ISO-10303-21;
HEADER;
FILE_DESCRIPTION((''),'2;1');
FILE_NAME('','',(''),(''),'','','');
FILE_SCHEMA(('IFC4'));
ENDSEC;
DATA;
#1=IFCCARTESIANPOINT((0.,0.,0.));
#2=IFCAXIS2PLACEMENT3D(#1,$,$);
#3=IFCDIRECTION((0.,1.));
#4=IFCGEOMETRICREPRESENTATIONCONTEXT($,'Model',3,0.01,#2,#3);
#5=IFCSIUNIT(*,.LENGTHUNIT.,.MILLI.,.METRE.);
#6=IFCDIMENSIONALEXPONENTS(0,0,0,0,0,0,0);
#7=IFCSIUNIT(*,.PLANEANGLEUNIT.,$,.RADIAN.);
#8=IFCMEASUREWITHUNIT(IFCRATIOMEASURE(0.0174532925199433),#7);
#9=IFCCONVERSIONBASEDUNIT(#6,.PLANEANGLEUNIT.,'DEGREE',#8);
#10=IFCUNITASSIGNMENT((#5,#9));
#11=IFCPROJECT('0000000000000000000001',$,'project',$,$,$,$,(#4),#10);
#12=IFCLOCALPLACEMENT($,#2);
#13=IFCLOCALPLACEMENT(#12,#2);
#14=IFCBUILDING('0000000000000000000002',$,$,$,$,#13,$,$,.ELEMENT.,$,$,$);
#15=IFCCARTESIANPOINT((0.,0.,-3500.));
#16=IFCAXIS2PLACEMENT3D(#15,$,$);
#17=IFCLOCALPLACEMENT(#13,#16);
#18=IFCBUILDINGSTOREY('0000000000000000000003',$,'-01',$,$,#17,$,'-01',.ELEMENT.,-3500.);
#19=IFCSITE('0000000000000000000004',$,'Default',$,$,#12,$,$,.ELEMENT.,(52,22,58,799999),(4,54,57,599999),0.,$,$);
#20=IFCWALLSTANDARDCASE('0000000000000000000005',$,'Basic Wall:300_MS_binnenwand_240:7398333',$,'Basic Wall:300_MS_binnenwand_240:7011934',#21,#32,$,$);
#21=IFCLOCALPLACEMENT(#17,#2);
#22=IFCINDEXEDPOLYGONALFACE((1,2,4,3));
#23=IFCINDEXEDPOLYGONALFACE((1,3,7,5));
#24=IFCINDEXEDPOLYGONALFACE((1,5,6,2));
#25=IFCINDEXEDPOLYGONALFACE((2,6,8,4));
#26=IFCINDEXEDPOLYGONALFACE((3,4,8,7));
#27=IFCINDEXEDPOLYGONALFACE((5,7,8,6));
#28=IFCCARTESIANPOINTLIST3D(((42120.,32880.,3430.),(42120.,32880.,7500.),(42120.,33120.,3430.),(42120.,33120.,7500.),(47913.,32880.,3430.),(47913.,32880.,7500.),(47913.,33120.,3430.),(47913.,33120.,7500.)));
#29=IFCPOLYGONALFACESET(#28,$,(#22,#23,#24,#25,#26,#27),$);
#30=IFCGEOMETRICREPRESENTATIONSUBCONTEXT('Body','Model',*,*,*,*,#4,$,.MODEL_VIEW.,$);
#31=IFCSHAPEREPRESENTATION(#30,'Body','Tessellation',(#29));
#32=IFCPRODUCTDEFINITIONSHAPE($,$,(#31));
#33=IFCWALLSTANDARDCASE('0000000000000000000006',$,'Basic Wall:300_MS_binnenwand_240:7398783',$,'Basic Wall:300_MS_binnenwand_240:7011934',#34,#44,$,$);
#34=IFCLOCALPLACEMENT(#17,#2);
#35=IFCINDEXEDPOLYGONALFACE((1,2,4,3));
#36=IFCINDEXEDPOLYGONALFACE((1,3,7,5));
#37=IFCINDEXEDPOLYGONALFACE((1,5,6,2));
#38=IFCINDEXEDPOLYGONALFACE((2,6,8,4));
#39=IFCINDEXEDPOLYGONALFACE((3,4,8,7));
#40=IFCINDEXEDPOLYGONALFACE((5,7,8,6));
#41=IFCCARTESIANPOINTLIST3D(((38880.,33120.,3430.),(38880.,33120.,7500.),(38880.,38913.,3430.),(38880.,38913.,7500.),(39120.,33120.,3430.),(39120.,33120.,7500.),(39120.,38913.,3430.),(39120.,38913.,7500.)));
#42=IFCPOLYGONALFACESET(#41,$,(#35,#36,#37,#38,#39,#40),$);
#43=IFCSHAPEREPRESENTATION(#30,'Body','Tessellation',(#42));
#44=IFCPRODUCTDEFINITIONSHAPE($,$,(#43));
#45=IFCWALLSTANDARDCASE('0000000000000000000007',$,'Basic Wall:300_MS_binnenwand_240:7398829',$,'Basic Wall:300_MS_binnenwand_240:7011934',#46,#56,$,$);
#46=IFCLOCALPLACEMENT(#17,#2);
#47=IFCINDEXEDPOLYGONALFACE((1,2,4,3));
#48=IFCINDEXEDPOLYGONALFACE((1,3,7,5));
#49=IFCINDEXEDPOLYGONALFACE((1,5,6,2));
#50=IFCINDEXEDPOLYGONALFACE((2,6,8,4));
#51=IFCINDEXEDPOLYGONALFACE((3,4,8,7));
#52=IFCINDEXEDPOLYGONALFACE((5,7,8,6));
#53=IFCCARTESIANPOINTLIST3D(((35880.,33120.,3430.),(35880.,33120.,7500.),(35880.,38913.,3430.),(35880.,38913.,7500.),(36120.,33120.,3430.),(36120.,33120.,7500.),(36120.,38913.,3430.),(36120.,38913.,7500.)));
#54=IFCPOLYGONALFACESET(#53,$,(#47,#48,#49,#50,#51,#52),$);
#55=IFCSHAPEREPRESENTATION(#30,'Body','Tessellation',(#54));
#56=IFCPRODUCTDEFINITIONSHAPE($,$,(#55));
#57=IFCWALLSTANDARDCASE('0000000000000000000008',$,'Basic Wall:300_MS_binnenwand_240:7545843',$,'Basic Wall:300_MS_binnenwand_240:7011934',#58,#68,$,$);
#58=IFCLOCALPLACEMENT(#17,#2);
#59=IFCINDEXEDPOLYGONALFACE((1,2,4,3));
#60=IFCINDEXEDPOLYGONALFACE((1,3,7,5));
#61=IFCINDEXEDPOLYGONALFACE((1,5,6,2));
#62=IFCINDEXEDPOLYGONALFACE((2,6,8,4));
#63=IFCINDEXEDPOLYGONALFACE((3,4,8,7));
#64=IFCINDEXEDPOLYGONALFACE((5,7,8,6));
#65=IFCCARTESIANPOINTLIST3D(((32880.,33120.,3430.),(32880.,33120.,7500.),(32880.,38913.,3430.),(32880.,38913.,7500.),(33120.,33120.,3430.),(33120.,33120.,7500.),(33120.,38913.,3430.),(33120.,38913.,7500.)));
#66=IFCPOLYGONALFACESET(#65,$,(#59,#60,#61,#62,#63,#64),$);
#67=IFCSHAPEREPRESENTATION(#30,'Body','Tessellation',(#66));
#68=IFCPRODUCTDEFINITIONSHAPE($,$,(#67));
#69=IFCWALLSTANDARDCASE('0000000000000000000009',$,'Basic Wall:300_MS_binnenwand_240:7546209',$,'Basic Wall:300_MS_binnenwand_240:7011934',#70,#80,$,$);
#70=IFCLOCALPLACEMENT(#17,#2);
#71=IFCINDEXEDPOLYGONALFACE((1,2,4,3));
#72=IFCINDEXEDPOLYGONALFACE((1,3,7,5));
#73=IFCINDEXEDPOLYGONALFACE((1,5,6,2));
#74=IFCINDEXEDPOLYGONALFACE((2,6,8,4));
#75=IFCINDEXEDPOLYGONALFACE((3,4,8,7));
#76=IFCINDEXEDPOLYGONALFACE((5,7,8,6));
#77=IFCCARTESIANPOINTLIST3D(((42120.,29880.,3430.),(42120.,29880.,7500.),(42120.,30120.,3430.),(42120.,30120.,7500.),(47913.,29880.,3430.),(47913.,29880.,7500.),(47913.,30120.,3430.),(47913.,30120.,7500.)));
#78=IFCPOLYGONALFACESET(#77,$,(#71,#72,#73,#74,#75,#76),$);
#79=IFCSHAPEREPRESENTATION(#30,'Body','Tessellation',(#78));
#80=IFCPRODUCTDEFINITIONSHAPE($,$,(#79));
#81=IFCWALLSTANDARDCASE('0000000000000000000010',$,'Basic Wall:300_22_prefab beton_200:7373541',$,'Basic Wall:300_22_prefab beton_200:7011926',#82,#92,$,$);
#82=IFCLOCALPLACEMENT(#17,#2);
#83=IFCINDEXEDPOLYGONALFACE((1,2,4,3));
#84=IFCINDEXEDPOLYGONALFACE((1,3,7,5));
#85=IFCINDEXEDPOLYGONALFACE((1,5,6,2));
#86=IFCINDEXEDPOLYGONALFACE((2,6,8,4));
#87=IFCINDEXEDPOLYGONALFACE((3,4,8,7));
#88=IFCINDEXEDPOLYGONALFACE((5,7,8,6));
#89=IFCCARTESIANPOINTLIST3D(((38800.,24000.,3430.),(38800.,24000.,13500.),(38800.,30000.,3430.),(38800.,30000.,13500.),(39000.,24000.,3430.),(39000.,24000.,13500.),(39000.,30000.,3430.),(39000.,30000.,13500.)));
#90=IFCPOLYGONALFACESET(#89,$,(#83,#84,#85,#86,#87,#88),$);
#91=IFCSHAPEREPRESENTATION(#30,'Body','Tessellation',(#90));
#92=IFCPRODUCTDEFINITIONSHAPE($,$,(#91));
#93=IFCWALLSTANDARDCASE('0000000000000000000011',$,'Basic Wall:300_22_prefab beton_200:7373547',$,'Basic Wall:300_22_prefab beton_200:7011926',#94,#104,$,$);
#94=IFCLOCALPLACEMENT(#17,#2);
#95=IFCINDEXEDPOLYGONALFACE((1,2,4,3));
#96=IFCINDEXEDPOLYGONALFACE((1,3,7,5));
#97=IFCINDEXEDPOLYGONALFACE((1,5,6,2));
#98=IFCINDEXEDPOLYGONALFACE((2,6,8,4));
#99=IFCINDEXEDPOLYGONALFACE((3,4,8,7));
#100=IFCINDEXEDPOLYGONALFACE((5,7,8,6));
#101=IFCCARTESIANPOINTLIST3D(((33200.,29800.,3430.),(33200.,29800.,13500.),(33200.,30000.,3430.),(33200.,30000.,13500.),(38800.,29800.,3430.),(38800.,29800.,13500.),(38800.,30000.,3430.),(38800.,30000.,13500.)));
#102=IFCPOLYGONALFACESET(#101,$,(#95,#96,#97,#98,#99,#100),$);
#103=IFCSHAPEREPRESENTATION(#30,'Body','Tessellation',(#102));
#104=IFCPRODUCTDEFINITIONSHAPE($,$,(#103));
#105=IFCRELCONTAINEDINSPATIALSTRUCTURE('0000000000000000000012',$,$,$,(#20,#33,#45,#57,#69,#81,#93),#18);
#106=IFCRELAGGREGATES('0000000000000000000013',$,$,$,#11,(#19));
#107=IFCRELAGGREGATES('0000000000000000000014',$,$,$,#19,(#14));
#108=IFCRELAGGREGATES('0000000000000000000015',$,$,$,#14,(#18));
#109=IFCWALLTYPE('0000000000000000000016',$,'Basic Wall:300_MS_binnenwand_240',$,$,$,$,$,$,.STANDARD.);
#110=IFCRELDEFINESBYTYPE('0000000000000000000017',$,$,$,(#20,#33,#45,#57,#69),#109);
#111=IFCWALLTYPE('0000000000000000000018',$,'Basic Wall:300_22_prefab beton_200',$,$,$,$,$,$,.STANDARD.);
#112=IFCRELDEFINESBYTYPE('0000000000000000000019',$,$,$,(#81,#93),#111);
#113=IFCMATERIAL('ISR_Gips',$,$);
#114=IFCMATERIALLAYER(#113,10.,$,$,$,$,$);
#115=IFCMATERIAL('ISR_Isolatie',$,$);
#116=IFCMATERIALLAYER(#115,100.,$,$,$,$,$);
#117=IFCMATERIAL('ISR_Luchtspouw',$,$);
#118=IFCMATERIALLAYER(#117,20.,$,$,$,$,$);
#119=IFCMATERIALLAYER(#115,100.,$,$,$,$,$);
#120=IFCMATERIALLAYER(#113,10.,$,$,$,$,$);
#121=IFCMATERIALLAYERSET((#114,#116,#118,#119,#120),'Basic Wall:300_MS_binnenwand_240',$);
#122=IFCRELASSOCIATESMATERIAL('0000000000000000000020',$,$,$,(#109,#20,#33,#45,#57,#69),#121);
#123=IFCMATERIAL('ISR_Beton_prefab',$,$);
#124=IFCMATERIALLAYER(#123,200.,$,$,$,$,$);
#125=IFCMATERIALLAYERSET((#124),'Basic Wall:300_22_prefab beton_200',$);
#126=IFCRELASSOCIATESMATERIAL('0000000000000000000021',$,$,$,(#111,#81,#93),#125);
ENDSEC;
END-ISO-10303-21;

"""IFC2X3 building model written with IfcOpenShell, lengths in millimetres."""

from ifc_helpers import new_model, entity, si_unit, converted_unit, direction, frame, frame_2d, origin, place, context, subcontext, project, spatial, rectangle, extrude, material, layer, layer_set, layer_usage, type_object, element, save


model = new_model("IFC2X3")

# Units and contexts
model_context = context("Model", 3, precision=0.01, world=origin(), true_north=direction((0.0, 1.0)))
body_context = subcontext(model_context, "Body", "Model", "MODEL_VIEW")
ifc_project = project(units=[si_unit("LENGTHUNIT", "METRE", prefix="MILLI"), converted_unit("PLANEANGLEUNIT", "DEGREE", entity("IfcRatioMeasure", 0.0174532925199433), si_unit("PLANEANGLEUNIT", "RADIAN"), dimensions=[0, 0, 0, 0, 0, 0, 0])], contexts=[model_context])

# Site, building, storey
site_placement = place(None, origin())
site = spatial("IfcSite", under=ifc_project, at=site_placement, Name="Default", CompositionType="ELEMENT", RefLatitude=(52, 22, 58, 799999), RefLongitude=(4, 54, 57, 599999), RefElevation=0.0)
building_placement = place(site_placement, origin())
building = spatial("IfcBuilding", under=site, at=building_placement, CompositionType="ELEMENT")
storey_placement = place(building_placement, frame((0.0, 0.0, -3500.0)))
storey = spatial("IfcBuildingStorey", under=building, at=storey_placement, Name="-01", LongName="-01", CompositionType="ELEMENT", Elevation=-3500.0)

# Shared definitions
ifc_material_1 = material(Name="ISR_Gips")
ifc_material_2 = material(Name="ISR_Isolatie")

# Walls
ifc_layer_1 = layer(ifc_material_1, 10.0)
ifc_layer_2 = layer(ifc_material_2, 100.0)
ifc_material_3 = material(Name="ISR_Luchtspouw")
ifc_layer_3 = layer(ifc_material_3, 20.0)
ifc_layer_4 = layer(ifc_material_2, 100.0)
ifc_layer_5 = layer(ifc_material_1, 10.0)
ifc_layer_set_1 = layer_set([ifc_layer_1, ifc_layer_2, ifc_layer_3, ifc_layer_4, ifc_layer_5], Name="Basic Wall:300_MS_binnenwand_240")
ifc_layer_usage_1 = layer_usage(ifc_layer_set_1, "AXIS2", "POSITIVE", -120.0)
wall_type_1 = type_object("IfcWallType", Name="Basic Wall:300_MS_binnenwand_240", PredefinedType="STANDARD", material=ifc_layer_set_1)
wall_1_placement = place(storey_placement, frame((47913.0, 33000.0, 3430.0), z_axis=(0.0, 0.0, 1.0), x_axis=(-1.0, 0.0, 0.0)))
element("IfcWallStandardCase", 1, at=wall_1_placement, inside=storey, type_object=wall_type_1, material=ifc_layer_usage_1, Name="Basic Wall:300_MS_binnenwand_240:7398333", ObjectType="Basic Wall:300_MS_binnenwand_240:7011934", context=body_context, shape_type="SweptSolid", body=[
    extrude(rectangle(XDim=5793.0, YDim=240.0, at=frame_2d((2896.5, 0.0), x_axis=(-1.0, 0.0))), origin(), (0.0, 0.0, 1.0), 4070.0),
])
ifc_layer_usage_2 = layer_usage(ifc_layer_set_1, "AXIS2", "NEGATIVE", 120.0)
wall_2_placement = place(storey_placement, frame((39000.0, 33120.0, 3430.0), z_axis=(0.0, 0.0, 1.0), x_axis=(0.0, 1.0, 0.0)))
element("IfcWallStandardCase", 2, at=wall_2_placement, inside=storey, type_object=wall_type_1, material=ifc_layer_usage_2, Name="Basic Wall:300_MS_binnenwand_240:7398783", ObjectType="Basic Wall:300_MS_binnenwand_240:7011934", context=body_context, shape_type="SweptSolid", body=[
    extrude(rectangle(XDim=5793.0, YDim=240.0, at=frame_2d((2896.5, 0.0), x_axis=(-1.0, 0.0))), origin(), (0.0, 0.0, 1.0), 4070.0),
])
ifc_layer_usage_3 = layer_usage(ifc_layer_set_1, "AXIS2", "NEGATIVE", 120.0)
wall_3_placement = place(storey_placement, frame((36000.0, 33120.0, 3430.0), z_axis=(0.0, 0.0, 1.0), x_axis=(0.0, 1.0, 0.0)))
element("IfcWallStandardCase", 3, at=wall_3_placement, inside=storey, type_object=wall_type_1, material=ifc_layer_usage_3, Name="Basic Wall:300_MS_binnenwand_240:7398829", ObjectType="Basic Wall:300_MS_binnenwand_240:7011934", context=body_context, shape_type="SweptSolid", body=[
    extrude(rectangle(XDim=5793.0, YDim=240.0, at=frame_2d((2896.5, 0.0), x_axis=(-1.0, 0.0))), origin(), (0.0, 0.0, 1.0), 4070.0),
])
ifc_layer_usage_4 = layer_usage(ifc_layer_set_1, "AXIS2", "NEGATIVE", 120.0)
wall_4_placement = place(storey_placement, frame((33000.0, 33120.0, 3430.0), z_axis=(0.0, 0.0, 1.0), x_axis=(0.0, 1.0, 0.0)))
element("IfcWallStandardCase", 4, at=wall_4_placement, inside=storey, type_object=wall_type_1, material=ifc_layer_usage_4, Name="Basic Wall:300_MS_binnenwand_240:7545843", ObjectType="Basic Wall:300_MS_binnenwand_240:7011934", context=body_context, shape_type="SweptSolid", body=[
    extrude(rectangle(XDim=5793.0, YDim=240.0, at=frame_2d((2896.5, 0.0), x_axis=(-1.0, 0.0))), origin(), (0.0, 0.0, 1.0), 4070.0),
])
ifc_layer_usage_5 = layer_usage(ifc_layer_set_1, "AXIS2", "POSITIVE", -120.0)
wall_5_placement = place(storey_placement, frame((47913.0, 30000.0, 3430.0), z_axis=(0.0, 0.0, 1.0), x_axis=(-1.0, 0.0, 0.0)))
element("IfcWallStandardCase", 5, at=wall_5_placement, inside=storey, type_object=wall_type_1, material=ifc_layer_usage_5, Name="Basic Wall:300_MS_binnenwand_240:7546209", ObjectType="Basic Wall:300_MS_binnenwand_240:7011934", context=body_context, shape_type="SweptSolid", body=[
    extrude(rectangle(XDim=5793.0, YDim=240.0, at=frame_2d((2896.5, 0.0), x_axis=(-1.0, 0.0))), origin(), (0.0, 0.0, 1.0), 4070.0),
])
ifc_material_4 = material(Name="ISR_Beton_prefab")
ifc_layer_6 = layer(ifc_material_4, 200.0)
ifc_layer_set_2 = layer_set([ifc_layer_6], Name="Basic Wall:300_22_prefab beton_200")
ifc_layer_usage_6 = layer_usage(ifc_layer_set_2, "AXIS2", "NEGATIVE", 100.0)
wall_type_2 = type_object("IfcWallType", Name="Basic Wall:300_22_prefab beton_200", PredefinedType="STANDARD", material=ifc_layer_set_2)
wall_6_placement = place(storey_placement, frame((38900.0, 30000.0, 3430.0), z_axis=(0.0, 0.0, 1.0), x_axis=(0.0, -1.0, 0.0)))
element("IfcWallStandardCase", 6, at=wall_6_placement, inside=storey, type_object=wall_type_2, material=ifc_layer_usage_6, Name="Basic Wall:300_22_prefab beton_200:7373541", ObjectType="Basic Wall:300_22_prefab beton_200:7011926", context=body_context, shape_type="SweptSolid", body=[
    extrude(rectangle(XDim=6000.0, YDim=200.0, at=frame_2d((3000.0, 0.0), x_axis=(-1.0, 0.0))), origin(), (0.0, 0.0, 1.0), 10070.0),
])
ifc_layer_usage_7 = layer_usage(ifc_layer_set_2, "AXIS2", "NEGATIVE", 100.0)
wall_7_placement = place(storey_placement, frame((33200.0, 29900.0, 3430.0)))
element("IfcWallStandardCase", 7, at=wall_7_placement, inside=storey, type_object=wall_type_2, material=ifc_layer_usage_7, Name="Basic Wall:300_22_prefab beton_200:7373547", ObjectType="Basic Wall:300_22_prefab beton_200:7011926", context=body_context, shape_type="SweptSolid", body=[
    extrude(rectangle(XDim=5600.0, YDim=200.0, at=frame_2d((2800.0, 0.0), x_axis=(-1.0, 0.0))), origin(), (0.0, 0.0, 1.0), 10070.0),
])

save(model, "model.ifc")
